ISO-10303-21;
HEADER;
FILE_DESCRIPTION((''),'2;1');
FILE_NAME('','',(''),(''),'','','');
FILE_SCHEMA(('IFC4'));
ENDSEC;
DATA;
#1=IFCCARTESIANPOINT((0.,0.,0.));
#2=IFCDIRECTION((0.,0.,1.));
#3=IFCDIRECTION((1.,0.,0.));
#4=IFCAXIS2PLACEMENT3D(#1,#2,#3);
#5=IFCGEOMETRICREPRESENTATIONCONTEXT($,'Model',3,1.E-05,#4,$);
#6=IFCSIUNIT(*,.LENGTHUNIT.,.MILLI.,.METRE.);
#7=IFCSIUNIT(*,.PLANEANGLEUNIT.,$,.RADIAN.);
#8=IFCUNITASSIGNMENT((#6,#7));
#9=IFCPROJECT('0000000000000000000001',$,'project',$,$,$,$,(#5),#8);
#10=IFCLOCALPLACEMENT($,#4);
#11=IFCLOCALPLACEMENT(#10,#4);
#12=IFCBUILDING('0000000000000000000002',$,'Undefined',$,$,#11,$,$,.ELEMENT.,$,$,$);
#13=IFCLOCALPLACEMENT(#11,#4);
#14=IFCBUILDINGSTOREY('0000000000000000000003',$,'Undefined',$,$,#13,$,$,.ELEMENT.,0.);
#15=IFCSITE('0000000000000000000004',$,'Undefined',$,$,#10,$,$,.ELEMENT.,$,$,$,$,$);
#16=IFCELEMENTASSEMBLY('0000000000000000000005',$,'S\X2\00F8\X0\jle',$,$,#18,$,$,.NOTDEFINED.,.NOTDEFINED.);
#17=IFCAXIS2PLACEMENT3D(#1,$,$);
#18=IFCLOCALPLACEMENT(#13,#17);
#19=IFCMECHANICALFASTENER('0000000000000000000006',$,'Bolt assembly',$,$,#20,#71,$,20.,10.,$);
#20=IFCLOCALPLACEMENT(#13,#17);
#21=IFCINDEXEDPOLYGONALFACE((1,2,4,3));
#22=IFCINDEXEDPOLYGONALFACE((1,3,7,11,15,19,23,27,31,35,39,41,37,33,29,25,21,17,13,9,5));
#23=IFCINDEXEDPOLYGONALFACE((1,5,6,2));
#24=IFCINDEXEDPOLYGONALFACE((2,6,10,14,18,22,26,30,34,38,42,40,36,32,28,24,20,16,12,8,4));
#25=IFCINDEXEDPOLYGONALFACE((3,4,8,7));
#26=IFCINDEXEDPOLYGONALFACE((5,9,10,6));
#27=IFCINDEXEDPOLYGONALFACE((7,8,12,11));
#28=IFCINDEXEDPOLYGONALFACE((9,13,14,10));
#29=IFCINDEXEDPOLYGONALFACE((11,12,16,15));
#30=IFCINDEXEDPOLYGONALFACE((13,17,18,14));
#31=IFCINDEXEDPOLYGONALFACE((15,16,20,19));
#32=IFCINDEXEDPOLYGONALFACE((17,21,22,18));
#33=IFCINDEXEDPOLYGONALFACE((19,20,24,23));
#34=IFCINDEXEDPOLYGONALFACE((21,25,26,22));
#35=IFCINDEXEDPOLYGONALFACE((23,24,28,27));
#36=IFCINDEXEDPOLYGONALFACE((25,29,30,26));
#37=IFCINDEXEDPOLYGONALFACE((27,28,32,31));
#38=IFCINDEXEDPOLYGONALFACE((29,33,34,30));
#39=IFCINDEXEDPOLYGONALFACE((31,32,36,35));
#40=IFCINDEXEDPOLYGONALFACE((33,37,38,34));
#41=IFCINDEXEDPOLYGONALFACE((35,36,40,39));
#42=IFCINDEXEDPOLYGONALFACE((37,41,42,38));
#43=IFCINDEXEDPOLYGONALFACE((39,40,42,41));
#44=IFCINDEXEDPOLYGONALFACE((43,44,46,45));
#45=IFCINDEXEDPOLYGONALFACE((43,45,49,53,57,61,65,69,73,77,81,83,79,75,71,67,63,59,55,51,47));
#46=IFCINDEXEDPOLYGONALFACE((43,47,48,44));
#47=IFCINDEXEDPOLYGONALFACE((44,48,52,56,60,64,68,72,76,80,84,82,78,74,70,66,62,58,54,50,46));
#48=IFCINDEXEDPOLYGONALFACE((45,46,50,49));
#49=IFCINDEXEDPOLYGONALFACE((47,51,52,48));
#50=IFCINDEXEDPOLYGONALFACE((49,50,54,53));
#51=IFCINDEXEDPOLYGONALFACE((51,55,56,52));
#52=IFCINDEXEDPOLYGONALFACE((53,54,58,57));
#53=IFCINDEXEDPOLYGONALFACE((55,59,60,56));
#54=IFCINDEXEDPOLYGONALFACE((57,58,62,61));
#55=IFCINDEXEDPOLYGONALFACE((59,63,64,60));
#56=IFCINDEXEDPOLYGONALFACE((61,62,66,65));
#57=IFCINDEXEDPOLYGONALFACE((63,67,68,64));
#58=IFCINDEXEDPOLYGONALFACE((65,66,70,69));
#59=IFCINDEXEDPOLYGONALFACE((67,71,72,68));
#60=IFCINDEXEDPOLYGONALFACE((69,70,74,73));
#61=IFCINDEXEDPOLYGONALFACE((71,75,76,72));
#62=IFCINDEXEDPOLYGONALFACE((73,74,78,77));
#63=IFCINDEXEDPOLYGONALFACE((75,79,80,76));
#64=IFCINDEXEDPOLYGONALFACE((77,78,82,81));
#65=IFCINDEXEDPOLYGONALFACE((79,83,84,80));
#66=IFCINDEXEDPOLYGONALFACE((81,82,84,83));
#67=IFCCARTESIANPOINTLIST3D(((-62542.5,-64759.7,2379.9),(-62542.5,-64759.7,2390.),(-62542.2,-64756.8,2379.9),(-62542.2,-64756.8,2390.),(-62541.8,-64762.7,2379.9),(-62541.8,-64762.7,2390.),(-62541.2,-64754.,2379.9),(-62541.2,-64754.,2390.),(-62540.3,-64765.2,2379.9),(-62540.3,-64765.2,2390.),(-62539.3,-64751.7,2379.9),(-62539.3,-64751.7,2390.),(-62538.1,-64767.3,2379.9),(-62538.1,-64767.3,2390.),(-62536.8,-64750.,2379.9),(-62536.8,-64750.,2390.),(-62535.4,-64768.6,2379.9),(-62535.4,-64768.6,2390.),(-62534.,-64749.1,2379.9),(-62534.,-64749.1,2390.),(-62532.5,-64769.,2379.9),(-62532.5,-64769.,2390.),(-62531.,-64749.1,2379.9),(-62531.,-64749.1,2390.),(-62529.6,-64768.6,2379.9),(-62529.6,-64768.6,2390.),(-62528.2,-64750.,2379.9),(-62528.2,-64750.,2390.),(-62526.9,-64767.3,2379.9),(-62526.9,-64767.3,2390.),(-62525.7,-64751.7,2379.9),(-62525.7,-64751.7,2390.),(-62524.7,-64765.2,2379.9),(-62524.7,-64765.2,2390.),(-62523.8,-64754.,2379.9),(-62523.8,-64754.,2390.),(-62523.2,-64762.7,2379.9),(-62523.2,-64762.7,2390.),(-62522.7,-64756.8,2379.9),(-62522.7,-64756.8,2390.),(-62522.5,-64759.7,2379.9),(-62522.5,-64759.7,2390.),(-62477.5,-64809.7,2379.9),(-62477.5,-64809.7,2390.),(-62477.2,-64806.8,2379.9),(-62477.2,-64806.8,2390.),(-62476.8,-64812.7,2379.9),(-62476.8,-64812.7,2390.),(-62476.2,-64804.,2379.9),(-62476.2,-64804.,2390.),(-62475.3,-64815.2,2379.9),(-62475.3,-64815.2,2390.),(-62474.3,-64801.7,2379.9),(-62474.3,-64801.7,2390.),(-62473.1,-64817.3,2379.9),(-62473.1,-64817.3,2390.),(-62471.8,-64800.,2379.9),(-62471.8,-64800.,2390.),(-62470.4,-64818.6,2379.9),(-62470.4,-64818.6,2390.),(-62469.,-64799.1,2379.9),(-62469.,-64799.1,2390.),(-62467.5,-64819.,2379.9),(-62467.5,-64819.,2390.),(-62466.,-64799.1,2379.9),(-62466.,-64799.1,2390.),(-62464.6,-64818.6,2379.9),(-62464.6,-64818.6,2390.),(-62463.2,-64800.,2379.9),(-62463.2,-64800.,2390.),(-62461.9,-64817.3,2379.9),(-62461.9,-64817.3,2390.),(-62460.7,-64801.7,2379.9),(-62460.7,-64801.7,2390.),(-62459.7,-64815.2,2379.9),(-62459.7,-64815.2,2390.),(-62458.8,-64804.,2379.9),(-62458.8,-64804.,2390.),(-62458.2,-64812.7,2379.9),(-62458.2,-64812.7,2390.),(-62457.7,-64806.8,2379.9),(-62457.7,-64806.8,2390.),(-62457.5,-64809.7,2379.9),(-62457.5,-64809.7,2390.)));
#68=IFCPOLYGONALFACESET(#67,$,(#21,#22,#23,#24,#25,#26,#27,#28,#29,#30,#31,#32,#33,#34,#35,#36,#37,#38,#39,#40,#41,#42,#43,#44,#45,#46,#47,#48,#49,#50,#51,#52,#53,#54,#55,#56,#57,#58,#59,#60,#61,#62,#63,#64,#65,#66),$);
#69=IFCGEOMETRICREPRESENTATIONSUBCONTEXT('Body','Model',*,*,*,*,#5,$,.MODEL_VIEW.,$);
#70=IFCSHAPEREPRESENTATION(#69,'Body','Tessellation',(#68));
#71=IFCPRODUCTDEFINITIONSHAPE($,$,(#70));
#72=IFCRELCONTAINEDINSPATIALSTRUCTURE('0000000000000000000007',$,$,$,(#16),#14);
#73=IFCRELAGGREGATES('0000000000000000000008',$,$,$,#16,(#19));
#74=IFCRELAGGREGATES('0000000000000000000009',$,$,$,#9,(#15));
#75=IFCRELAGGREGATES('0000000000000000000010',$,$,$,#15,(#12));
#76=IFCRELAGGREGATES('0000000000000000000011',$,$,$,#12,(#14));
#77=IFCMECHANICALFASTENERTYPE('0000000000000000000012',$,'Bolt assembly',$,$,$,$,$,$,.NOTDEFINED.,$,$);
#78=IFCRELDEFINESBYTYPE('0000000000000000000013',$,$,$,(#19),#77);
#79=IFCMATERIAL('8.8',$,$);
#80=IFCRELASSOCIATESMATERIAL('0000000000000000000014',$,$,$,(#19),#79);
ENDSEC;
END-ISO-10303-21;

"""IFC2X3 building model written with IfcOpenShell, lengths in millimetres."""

from ifc_helpers import new_model, si_unit, frame, origin_with_axes, origin_2d_with_axis, place, context, subcontext, project, spatial, circle, extrude, source, transform, mapped, material, type_object, element, aggregate, save


model = new_model("IFC2X3")

# Units and contexts
model_context = context("Model", 3, precision=1e-05, world=origin_with_axes())
body_context = subcontext(model_context, "Body", "Model", "MODEL_VIEW")
ifc_project = project(units=[si_unit("LENGTHUNIT", "METRE", prefix="MILLI"), si_unit("PLANEANGLEUNIT", "RADIAN")], contexts=[model_context])

# Site, building, storey
site_placement = place(None, origin_with_axes())
site = spatial("IfcSite", under=ifc_project, at=site_placement, Name="Undefined", CompositionType="ELEMENT")
building_placement = place(site_placement, origin_with_axes())
building = spatial("IfcBuilding", under=site, at=building_placement, Name="Undefined", CompositionType="ELEMENT")
storey_placement = place(building_placement, origin_with_axes())
storey = spatial("IfcBuildingStorey", under=building, at=storey_placement, Name="Undefined", CompositionType="ELEMENT", Elevation=0.0)

# Element assembly
assembly_1_placement = place(storey_placement, origin_with_axes())
assembly_1 = element("IfcElementAssembly", 1, at=assembly_1_placement, inside=storey, Name="Søjle", AssemblyPlace="NOTDEFINED", PredefinedType="NOTDEFINED")

# Shared definitions
ifc_material_1 = material(Name="8.8")
mechanical_fastener_type = type_object("IfcMechanicalFastenerType", Name="Bolt assembly")
shared_shape_1 = source(origin_with_axes(), body_context, "Body", "SweptSolid", [
    extrude(circle(Radius=10.0, at=origin_2d_with_axis()), frame((0.0, 0.0, 0.0), z_axis=(0.0, 1.0, 0.0), x_axis=(1.0, 0.0, 0.0)), (0.0, 0.0, 1.0), 10.1),
])

# Mechanical fastener
mechanical_fastener_1_placement = place(assembly_1_placement, frame((-62500.0, -64759.0, 2390.0), z_axis=(1.0, 0.0, 0.0), x_axis=(0.0, -1.0, 0.0)))
mechanical_fastener_1 = element("IfcMechanicalFastener", 2, at=mechanical_fastener_1_placement, type_object=mechanical_fastener_type, material=ifc_material_1, Name="Bolt assembly", NominalDiameter=20.0, NominalLength=10.0, context=body_context, shape_type="MappedRepresentation", body=[
    mapped(shared_shape_1, transform((0.0, 0.0, -32.5))),
    mapped(shared_shape_1, transform((50.0, 0.0, 32.5))),
])
aggregate(assembly_1, [mechanical_fastener_1])

save(model, "model.ifc")
